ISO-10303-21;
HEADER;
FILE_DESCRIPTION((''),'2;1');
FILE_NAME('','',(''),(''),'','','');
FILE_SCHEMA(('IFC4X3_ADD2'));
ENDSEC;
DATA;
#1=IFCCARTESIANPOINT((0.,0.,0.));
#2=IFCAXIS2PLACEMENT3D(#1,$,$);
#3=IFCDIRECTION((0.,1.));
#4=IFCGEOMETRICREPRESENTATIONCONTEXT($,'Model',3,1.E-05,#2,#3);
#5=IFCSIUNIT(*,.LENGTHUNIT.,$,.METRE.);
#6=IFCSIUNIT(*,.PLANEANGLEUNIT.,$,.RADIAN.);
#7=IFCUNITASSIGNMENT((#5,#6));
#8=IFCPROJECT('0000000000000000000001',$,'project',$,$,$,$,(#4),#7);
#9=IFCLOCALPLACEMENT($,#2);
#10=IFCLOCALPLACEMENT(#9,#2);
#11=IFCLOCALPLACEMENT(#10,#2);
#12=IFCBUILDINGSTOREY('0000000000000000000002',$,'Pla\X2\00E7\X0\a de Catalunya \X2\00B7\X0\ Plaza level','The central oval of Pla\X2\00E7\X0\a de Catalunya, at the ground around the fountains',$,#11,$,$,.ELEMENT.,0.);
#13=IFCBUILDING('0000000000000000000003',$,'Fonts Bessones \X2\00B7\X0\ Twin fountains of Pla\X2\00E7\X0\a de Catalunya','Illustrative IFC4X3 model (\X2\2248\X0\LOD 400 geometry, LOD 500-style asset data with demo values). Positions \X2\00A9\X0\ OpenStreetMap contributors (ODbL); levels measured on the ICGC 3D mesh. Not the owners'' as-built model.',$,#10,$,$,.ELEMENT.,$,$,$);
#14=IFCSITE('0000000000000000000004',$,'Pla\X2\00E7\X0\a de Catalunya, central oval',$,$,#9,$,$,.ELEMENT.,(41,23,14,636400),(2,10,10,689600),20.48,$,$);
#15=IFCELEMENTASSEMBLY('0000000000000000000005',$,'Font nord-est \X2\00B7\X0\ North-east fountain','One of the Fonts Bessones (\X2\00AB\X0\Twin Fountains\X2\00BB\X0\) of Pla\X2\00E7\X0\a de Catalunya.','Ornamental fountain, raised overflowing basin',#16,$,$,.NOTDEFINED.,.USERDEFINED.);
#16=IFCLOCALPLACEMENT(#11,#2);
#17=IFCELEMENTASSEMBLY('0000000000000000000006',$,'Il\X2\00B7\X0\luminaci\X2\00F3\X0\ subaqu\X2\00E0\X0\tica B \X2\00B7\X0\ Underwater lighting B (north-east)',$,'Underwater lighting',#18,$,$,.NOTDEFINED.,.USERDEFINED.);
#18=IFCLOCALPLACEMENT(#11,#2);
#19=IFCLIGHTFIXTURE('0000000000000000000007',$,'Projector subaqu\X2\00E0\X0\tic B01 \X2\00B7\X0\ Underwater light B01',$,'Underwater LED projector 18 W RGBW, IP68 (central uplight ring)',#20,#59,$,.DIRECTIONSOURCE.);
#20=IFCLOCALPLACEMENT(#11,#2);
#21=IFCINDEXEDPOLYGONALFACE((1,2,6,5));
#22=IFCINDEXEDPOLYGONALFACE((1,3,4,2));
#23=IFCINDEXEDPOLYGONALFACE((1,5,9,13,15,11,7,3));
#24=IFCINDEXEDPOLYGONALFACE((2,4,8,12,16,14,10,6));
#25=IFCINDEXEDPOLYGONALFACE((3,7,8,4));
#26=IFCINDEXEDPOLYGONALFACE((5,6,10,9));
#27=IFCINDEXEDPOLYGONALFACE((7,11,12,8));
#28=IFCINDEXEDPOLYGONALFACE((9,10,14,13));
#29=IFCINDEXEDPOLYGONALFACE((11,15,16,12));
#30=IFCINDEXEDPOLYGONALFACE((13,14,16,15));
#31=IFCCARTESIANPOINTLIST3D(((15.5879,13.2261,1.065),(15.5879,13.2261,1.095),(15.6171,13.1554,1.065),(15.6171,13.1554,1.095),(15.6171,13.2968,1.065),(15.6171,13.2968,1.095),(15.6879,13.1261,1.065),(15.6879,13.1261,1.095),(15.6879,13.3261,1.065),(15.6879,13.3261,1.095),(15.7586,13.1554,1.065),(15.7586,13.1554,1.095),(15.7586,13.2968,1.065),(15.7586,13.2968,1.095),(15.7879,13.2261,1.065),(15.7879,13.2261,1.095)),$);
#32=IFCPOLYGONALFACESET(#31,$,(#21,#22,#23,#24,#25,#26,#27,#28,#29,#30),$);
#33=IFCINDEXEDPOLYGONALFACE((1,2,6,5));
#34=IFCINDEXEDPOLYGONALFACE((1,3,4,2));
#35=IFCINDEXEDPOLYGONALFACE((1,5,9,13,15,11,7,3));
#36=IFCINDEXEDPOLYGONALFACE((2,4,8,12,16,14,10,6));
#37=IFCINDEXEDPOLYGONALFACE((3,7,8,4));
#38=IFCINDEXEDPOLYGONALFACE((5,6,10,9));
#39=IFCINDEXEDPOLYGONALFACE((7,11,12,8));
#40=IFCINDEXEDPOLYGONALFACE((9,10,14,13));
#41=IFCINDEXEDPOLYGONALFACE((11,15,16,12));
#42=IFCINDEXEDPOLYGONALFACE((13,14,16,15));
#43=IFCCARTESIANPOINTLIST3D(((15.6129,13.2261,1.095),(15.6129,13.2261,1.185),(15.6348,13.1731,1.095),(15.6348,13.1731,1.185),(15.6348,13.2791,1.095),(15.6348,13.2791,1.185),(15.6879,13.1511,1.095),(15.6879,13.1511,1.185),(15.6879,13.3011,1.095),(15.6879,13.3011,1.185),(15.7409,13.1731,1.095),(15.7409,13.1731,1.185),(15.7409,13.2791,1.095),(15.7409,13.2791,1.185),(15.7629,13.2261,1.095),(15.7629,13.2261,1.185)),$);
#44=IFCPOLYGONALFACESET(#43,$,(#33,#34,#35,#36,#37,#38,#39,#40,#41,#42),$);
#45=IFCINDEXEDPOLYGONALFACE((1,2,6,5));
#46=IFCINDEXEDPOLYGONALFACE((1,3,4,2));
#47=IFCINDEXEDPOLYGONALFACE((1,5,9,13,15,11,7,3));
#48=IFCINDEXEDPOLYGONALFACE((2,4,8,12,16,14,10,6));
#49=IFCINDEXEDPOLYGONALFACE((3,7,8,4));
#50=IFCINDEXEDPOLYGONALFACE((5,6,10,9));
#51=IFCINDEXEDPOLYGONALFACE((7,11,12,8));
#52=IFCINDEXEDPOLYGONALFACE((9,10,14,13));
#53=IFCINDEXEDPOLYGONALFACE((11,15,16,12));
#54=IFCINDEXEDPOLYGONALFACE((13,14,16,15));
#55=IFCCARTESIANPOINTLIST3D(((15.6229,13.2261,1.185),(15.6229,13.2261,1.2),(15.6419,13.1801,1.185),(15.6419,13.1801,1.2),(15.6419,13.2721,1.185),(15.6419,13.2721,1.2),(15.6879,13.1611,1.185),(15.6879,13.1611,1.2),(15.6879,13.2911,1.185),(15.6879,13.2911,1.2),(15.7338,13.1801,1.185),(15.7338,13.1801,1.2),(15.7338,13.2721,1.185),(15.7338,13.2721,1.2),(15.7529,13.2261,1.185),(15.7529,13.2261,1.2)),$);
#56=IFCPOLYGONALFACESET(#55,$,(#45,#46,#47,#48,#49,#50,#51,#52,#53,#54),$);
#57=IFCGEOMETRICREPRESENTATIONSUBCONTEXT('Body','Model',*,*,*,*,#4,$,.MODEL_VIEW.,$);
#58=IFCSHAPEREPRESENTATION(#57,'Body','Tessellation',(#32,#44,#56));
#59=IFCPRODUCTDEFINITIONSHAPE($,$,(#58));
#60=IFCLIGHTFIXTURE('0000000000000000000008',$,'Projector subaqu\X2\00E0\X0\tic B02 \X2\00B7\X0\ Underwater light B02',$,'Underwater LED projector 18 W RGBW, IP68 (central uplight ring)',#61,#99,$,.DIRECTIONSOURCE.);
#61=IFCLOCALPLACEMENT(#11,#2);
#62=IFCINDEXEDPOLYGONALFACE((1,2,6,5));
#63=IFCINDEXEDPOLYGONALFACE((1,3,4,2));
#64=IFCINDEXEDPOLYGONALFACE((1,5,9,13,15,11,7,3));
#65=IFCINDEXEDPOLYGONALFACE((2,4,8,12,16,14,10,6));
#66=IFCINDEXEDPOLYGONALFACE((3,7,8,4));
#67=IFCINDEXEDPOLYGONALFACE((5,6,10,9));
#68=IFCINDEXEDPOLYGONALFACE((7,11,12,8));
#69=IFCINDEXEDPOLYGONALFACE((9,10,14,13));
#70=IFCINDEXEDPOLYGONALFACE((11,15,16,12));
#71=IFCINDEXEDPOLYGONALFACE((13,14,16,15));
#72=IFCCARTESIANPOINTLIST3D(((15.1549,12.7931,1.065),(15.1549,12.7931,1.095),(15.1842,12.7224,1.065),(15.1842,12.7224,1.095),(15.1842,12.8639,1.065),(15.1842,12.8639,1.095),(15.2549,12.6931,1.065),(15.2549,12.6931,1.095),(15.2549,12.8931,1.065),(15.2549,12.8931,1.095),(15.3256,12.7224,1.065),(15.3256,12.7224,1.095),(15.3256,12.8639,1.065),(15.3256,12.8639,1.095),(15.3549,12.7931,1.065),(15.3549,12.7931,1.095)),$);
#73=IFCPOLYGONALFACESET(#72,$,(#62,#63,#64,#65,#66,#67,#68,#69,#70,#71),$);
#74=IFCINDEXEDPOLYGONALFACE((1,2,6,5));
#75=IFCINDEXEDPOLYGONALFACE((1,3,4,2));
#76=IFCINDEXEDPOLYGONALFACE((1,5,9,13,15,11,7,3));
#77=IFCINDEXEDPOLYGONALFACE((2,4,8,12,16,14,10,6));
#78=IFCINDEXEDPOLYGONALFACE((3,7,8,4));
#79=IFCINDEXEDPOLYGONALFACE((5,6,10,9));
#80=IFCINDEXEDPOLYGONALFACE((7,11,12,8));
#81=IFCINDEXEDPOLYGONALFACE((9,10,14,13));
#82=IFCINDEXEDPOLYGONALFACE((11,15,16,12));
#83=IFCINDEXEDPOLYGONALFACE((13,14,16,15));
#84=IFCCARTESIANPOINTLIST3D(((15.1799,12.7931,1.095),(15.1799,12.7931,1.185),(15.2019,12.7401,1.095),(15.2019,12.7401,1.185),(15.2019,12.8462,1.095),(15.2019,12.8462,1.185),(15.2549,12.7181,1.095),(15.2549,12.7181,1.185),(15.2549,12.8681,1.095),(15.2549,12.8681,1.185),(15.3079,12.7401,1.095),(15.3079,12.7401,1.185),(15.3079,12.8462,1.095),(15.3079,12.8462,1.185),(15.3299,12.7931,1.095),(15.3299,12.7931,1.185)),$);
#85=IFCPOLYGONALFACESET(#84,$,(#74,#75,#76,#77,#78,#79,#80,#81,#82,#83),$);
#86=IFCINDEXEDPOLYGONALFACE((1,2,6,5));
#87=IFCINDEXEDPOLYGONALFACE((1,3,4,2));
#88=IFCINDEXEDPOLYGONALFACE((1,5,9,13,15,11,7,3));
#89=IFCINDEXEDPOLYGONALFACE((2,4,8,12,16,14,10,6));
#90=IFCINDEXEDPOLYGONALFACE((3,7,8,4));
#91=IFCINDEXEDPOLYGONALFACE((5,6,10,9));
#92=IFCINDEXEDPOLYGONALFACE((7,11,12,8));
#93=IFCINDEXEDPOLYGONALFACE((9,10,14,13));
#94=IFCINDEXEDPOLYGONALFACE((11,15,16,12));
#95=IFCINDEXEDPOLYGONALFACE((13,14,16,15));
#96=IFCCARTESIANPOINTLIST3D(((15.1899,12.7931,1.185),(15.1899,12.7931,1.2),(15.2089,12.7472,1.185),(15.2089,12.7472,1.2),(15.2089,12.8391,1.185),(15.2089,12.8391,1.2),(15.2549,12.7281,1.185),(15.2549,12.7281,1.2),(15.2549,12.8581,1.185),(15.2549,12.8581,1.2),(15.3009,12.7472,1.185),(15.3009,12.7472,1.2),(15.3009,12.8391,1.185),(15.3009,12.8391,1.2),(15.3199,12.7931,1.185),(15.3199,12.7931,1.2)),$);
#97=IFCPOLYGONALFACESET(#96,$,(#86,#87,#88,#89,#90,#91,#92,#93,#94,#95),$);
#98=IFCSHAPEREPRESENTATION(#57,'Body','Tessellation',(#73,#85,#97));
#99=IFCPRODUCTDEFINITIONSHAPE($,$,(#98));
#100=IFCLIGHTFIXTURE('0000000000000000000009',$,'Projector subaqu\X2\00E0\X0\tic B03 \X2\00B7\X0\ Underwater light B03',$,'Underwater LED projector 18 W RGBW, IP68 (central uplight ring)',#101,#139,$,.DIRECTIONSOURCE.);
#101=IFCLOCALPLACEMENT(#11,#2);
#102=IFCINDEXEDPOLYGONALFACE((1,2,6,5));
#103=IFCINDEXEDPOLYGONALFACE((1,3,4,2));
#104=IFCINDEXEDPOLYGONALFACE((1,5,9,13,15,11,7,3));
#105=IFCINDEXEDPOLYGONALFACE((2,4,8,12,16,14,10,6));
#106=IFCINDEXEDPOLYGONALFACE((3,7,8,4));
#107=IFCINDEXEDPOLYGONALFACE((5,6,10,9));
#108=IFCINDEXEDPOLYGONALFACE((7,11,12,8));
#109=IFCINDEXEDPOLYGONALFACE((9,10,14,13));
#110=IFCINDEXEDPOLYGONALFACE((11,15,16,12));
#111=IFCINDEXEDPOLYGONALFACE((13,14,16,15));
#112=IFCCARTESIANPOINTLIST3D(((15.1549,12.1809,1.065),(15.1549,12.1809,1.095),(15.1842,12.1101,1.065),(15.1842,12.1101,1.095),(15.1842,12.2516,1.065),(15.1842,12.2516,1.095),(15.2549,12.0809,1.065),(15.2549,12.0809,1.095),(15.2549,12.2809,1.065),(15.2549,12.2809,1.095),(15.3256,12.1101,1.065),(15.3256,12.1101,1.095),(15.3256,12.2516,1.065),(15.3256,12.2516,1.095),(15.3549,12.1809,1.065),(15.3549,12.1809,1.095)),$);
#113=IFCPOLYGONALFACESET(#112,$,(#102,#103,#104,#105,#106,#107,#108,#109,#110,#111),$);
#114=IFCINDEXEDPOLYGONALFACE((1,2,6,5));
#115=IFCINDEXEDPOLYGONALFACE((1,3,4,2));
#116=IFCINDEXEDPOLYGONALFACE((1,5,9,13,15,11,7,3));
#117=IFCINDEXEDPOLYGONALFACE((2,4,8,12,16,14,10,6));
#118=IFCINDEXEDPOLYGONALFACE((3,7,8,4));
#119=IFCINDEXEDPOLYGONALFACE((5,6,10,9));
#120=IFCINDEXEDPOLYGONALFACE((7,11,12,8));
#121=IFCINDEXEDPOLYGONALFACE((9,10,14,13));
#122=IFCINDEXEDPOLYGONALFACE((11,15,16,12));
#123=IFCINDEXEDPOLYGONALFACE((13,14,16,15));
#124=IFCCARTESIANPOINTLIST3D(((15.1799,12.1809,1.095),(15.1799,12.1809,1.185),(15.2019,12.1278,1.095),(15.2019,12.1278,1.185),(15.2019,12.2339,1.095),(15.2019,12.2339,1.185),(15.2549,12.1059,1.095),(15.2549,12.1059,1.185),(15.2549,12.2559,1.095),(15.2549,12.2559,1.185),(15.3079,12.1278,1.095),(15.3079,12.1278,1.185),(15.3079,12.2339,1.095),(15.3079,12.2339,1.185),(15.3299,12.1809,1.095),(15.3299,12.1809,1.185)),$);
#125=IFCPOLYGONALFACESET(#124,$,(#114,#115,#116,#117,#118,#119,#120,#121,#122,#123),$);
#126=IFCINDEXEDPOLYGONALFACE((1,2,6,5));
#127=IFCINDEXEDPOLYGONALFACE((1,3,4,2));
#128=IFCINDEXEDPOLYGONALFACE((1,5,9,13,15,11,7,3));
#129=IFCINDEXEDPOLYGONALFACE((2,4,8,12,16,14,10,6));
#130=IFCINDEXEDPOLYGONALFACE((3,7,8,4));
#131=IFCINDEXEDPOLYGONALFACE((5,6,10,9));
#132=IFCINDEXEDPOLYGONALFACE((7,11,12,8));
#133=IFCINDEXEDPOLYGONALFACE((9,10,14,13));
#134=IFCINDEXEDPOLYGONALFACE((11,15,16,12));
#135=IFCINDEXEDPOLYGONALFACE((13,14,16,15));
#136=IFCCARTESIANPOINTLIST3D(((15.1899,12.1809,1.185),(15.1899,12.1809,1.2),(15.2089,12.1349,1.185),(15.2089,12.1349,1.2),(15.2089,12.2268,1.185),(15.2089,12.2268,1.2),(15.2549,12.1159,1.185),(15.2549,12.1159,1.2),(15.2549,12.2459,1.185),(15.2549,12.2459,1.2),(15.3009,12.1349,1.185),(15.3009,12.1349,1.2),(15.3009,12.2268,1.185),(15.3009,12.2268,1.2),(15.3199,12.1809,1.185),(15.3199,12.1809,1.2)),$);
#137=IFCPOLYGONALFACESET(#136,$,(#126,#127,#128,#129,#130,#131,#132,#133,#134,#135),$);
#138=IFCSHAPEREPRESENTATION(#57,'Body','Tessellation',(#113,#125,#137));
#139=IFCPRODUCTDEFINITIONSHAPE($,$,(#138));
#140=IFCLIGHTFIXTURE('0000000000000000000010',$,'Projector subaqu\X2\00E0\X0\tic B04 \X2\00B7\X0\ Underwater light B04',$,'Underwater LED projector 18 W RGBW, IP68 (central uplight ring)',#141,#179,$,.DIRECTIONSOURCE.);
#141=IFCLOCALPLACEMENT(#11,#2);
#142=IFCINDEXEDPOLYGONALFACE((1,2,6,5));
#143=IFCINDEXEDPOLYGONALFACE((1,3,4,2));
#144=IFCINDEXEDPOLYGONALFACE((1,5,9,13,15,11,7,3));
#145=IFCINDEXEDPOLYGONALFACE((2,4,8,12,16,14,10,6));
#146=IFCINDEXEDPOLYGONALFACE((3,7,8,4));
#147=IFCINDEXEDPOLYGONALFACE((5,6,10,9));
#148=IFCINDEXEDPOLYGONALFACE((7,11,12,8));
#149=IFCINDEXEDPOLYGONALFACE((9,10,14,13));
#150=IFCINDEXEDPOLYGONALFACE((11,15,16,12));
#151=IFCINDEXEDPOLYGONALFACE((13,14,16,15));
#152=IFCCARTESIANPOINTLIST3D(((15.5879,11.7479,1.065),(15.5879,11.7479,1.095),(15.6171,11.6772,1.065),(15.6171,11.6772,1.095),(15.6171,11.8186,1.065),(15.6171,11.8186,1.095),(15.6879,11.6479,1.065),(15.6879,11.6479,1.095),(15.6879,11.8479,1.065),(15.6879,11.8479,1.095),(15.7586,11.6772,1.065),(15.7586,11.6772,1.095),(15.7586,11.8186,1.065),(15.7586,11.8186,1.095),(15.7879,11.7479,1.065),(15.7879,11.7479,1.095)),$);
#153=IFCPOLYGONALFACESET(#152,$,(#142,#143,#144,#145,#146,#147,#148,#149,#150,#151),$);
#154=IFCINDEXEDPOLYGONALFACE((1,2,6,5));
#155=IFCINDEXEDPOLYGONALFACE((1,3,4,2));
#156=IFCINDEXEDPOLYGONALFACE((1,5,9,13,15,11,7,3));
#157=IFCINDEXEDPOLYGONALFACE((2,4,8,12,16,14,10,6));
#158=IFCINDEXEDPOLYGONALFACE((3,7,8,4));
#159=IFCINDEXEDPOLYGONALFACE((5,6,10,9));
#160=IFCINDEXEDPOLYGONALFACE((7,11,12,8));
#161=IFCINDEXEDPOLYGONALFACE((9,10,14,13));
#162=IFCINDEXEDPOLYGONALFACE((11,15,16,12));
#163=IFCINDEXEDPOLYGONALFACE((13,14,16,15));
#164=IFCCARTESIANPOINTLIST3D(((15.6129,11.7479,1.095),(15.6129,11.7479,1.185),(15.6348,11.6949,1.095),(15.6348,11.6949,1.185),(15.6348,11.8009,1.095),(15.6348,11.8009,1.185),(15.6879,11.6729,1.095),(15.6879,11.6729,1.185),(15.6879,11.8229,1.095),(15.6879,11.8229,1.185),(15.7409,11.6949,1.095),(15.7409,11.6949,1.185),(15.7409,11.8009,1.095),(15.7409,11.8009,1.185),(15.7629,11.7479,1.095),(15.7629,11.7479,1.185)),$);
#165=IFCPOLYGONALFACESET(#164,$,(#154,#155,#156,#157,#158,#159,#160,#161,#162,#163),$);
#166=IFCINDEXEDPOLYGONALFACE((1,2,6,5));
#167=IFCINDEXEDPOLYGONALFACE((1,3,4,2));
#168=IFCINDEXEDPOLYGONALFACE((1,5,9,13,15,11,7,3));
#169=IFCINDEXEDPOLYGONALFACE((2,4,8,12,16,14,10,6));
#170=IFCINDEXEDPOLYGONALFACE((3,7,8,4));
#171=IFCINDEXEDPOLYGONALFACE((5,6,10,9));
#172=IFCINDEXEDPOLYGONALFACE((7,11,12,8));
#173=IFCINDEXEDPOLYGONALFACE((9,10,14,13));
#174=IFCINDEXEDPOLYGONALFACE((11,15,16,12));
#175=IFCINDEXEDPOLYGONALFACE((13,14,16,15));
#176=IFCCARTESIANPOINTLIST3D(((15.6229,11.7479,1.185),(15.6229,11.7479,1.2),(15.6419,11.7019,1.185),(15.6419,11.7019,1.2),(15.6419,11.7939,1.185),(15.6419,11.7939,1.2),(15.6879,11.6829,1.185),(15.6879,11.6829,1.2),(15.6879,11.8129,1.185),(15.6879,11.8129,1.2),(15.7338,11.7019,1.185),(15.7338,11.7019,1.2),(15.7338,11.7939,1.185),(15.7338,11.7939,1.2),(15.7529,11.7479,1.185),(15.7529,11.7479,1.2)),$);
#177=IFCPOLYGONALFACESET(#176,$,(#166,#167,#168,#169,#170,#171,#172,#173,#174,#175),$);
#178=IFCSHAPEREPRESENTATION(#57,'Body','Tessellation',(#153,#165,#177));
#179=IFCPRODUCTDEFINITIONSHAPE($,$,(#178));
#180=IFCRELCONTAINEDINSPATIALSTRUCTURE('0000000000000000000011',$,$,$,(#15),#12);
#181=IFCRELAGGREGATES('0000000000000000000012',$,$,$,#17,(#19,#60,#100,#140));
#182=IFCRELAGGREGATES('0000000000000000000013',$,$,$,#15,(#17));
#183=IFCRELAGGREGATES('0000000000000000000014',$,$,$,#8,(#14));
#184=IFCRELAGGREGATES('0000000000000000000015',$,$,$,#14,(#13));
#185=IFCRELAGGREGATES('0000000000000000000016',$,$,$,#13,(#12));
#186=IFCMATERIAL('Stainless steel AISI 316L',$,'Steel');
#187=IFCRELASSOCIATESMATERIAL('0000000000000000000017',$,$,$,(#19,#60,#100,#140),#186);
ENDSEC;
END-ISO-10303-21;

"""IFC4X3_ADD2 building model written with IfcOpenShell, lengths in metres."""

from ifc_helpers import new_model, si_unit, direction, frame, origin, place, context, subcontext, project, spatial, polyline, outline, extrude, material, element, aggregate, save


model = new_model("IFC4X3_ADD2")

# Units and contexts
model_context = context("Model", 3, precision=1e-05, world=origin(), true_north=direction((0.0, 1.0)))
body_context = subcontext(model_context, "Body", "Model", "MODEL_VIEW")
ifc_project = project(units=[si_unit("LENGTHUNIT", "METRE"), si_unit("PLANEANGLEUNIT", "RADIAN")], contexts=[model_context])

# Site, building, storey
site_placement = place(None, origin())
site = spatial("IfcSite", under=ifc_project, at=site_placement, Name="Plaça de Catalunya, central oval", CompositionType="ELEMENT", RefLatitude=(41, 23, 14, 636400), RefLongitude=(2, 10, 10, 689600), RefElevation=20.48)
building_placement = place(site_placement, origin())
building = spatial("IfcBuilding", under=site, at=building_placement, Name="Fonts Bessones · Twin fountains of Plaça de Catalunya", Description="Illustrative IFC4X3 model (≈LOD 400 geometry, LOD 500-style asset data with demo values). Positions © OpenStreetMap contributors (ODbL); levels measured on the ICGC 3D mesh. Not the owners' as-built model.", CompositionType="ELEMENT")
storey_placement = place(building_placement, origin())
storey = spatial("IfcBuildingStorey", under=building, at=storey_placement, Name="Plaça de Catalunya · Plaza level", Description="The central oval of Plaça de Catalunya, at the ground around the fountains", CompositionType="ELEMENT", Elevation=0.0)

# Element assemblies, light fixtures
assembly_1_placement = place(building_placement, origin())
assembly_1 = element("IfcElementAssembly", 1, at=assembly_1_placement, inside=storey, Name="Font nord-est · North-east fountain", Description="One of the Fonts Bessones («Twin Fountains») of Plaça de Catalunya.", ObjectType="Ornamental fountain, raised overflowing basin", AssemblyPlace="NOTDEFINED", PredefinedType="USERDEFINED")
assembly_2_placement = place(building_placement, origin())
assembly_2 = element("IfcElementAssembly", 2, at=assembly_2_placement, Name="Il·luminació subaquàtica B · Underwater lighting B (north-east)", ObjectType="Underwater lighting", AssemblyPlace="NOTDEFINED", PredefinedType="USERDEFINED")
ifc_material_1 = material(Name="Stainless steel AISI 316L", Category="Steel")
light_fixture_1_placement = place(building_placement, origin())
light_fixture_1 = element("IfcLightFixture", 3, at=light_fixture_1_placement, material=ifc_material_1, Name="Projector subaquàtic B01 · Underwater light B01", ObjectType="Underwater LED projector 18 W RGBW, IP68 (central uplight ring)", PredefinedType="DIRECTIONSOURCE", context=body_context, shape_type="SweptSolid", body=[
    extrude(outline(polyline([(15.7879, 13.2261), (15.7586, 13.2968), (15.6879, 13.3261), (15.6171, 13.2968), (15.5879, 13.2261), (15.6171, 13.1554), (15.6879, 13.1261), (15.7586, 13.1554), (15.7879, 13.2261)])), frame((0.0, 0.0, 1.065)), (0.0, 0.0, 1.0), 0.03),
    extrude(outline(polyline([(15.7629, 13.2261), (15.7409, 13.2791), (15.6879, 13.3011), (15.6348, 13.2791), (15.6129, 13.2261), (15.6348, 13.1731), (15.6879, 13.1511), (15.7409, 13.1731), (15.7629, 13.2261)])), frame((0.0, 0.0, 1.095)), (0.0, 0.0, 1.0), 0.09),
    extrude(outline(polyline([(15.7529, 13.2261), (15.7338, 13.2721), (15.6879, 13.2911), (15.6419, 13.2721), (15.6229, 13.2261), (15.6419, 13.1801), (15.6879, 13.1611), (15.7338, 13.1801), (15.7529, 13.2261)])), frame((0.0, 0.0, 1.185)), (0.0, 0.0, 1.0), 0.015),
])
light_fixture_2_placement = place(building_placement, origin())
light_fixture_2 = element("IfcLightFixture", 4, at=light_fixture_2_placement, material=ifc_material_1, Name="Projector subaquàtic B02 · Underwater light B02", ObjectType="Underwater LED projector 18 W RGBW, IP68 (central uplight ring)", PredefinedType="DIRECTIONSOURCE", context=body_context, shape_type="SweptSolid", body=[
    extrude(outline(polyline([(15.3549, 12.7931), (15.3256, 12.8639), (15.2549, 12.8931), (15.1842, 12.8639), (15.1549, 12.7931), (15.1842, 12.7224), (15.2549, 12.6931), (15.3256, 12.7224), (15.3549, 12.7931)])), frame((0.0, 0.0, 1.065)), (0.0, 0.0, 1.0), 0.03),
    extrude(outline(polyline([(15.3299, 12.7931), (15.3079, 12.8462), (15.2549, 12.8681), (15.2019, 12.8462), (15.1799, 12.7931), (15.2019, 12.7401), (15.2549, 12.7181), (15.3079, 12.7401), (15.3299, 12.7931)])), frame((0.0, 0.0, 1.095)), (0.0, 0.0, 1.0), 0.09),
    extrude(outline(polyline([(15.3199, 12.7931), (15.3009, 12.8391), (15.2549, 12.8581), (15.2089, 12.8391), (15.1899, 12.7931), (15.2089, 12.7472), (15.2549, 12.7281), (15.3009, 12.7472), (15.3199, 12.7931)])), frame((0.0, 0.0, 1.185)), (0.0, 0.0, 1.0), 0.015),
])
light_fixture_3_placement = place(building_placement, origin())
light_fixture_3 = element("IfcLightFixture", 5, at=light_fixture_3_placement, material=ifc_material_1, Name="Projector subaquàtic B03 · Underwater light B03", ObjectType="Underwater LED projector 18 W RGBW, IP68 (central uplight ring)", PredefinedType="DIRECTIONSOURCE", context=body_context, shape_type="SweptSolid", body=[
    extrude(outline(polyline([(15.3549, 12.1809), (15.3256, 12.2516), (15.2549, 12.2809), (15.1842, 12.2516), (15.1549, 12.1809), (15.1842, 12.1101), (15.2549, 12.0809), (15.3256, 12.1101), (15.3549, 12.1809)])), frame((0.0, 0.0, 1.065)), (0.0, 0.0, 1.0), 0.03),
    extrude(outline(polyline([(15.3299, 12.1809), (15.3079, 12.2339), (15.2549, 12.2559), (15.2019, 12.2339), (15.1799, 12.1809), (15.2019, 12.1278), (15.2549, 12.1059), (15.3079, 12.1278), (15.3299, 12.1809)])), frame((0.0, 0.0, 1.095)), (0.0, 0.0, 1.0), 0.09),
    extrude(outline(polyline([(15.3199, 12.1809), (15.3009, 12.2268), (15.2549, 12.2459), (15.2089, 12.2268), (15.1899, 12.1809), (15.2089, 12.1349), (15.2549, 12.1159), (15.3009, 12.1349), (15.3199, 12.1809)])), frame((0.0, 0.0, 1.185)), (0.0, 0.0, 1.0), 0.015),
])
light_fixture_4_placement = place(building_placement, origin())
light_fixture_4 = element("IfcLightFixture", 6, at=light_fixture_4_placement, material=ifc_material_1, Name="Projector subaquàtic B04 · Underwater light B04", ObjectType="Underwater LED projector 18 W RGBW, IP68 (central uplight ring)", PredefinedType="DIRECTIONSOURCE", context=body_context, shape_type="SweptSolid", body=[
    extrude(outline(polyline([(15.7879, 11.7479), (15.7586, 11.8186), (15.6879, 11.8479), (15.6171, 11.8186), (15.5879, 11.7479), (15.6171, 11.6772), (15.6879, 11.6479), (15.7586, 11.6772), (15.7879, 11.7479)])), frame((0.0, 0.0, 1.065)), (0.0, 0.0, 1.0), 0.03),
    extrude(outline(polyline([(15.7629, 11.7479), (15.7409, 11.8009), (15.6879, 11.8229), (15.6348, 11.8009), (15.6129, 11.7479), (15.6348, 11.6949), (15.6879, 11.6729), (15.7409, 11.6949), (15.7629, 11.7479)])), frame((0.0, 0.0, 1.095)), (0.0, 0.0, 1.0), 0.09),
    extrude(outline(polyline([(15.7529, 11.7479), (15.7338, 11.7939), (15.6879, 11.8129), (15.6419, 11.7939), (15.6229, 11.7479), (15.6419, 11.7019), (15.6879, 11.6829), (15.7338, 11.7019), (15.7529, 11.7479)])), frame((0.0, 0.0, 1.185)), (0.0, 0.0, 1.0), 0.015),
])
aggregate(assembly_2, [light_fixture_1, light_fixture_2, light_fixture_3, light_fixture_4])
aggregate(assembly_1, [assembly_2])

save(model, "model.ifc")
